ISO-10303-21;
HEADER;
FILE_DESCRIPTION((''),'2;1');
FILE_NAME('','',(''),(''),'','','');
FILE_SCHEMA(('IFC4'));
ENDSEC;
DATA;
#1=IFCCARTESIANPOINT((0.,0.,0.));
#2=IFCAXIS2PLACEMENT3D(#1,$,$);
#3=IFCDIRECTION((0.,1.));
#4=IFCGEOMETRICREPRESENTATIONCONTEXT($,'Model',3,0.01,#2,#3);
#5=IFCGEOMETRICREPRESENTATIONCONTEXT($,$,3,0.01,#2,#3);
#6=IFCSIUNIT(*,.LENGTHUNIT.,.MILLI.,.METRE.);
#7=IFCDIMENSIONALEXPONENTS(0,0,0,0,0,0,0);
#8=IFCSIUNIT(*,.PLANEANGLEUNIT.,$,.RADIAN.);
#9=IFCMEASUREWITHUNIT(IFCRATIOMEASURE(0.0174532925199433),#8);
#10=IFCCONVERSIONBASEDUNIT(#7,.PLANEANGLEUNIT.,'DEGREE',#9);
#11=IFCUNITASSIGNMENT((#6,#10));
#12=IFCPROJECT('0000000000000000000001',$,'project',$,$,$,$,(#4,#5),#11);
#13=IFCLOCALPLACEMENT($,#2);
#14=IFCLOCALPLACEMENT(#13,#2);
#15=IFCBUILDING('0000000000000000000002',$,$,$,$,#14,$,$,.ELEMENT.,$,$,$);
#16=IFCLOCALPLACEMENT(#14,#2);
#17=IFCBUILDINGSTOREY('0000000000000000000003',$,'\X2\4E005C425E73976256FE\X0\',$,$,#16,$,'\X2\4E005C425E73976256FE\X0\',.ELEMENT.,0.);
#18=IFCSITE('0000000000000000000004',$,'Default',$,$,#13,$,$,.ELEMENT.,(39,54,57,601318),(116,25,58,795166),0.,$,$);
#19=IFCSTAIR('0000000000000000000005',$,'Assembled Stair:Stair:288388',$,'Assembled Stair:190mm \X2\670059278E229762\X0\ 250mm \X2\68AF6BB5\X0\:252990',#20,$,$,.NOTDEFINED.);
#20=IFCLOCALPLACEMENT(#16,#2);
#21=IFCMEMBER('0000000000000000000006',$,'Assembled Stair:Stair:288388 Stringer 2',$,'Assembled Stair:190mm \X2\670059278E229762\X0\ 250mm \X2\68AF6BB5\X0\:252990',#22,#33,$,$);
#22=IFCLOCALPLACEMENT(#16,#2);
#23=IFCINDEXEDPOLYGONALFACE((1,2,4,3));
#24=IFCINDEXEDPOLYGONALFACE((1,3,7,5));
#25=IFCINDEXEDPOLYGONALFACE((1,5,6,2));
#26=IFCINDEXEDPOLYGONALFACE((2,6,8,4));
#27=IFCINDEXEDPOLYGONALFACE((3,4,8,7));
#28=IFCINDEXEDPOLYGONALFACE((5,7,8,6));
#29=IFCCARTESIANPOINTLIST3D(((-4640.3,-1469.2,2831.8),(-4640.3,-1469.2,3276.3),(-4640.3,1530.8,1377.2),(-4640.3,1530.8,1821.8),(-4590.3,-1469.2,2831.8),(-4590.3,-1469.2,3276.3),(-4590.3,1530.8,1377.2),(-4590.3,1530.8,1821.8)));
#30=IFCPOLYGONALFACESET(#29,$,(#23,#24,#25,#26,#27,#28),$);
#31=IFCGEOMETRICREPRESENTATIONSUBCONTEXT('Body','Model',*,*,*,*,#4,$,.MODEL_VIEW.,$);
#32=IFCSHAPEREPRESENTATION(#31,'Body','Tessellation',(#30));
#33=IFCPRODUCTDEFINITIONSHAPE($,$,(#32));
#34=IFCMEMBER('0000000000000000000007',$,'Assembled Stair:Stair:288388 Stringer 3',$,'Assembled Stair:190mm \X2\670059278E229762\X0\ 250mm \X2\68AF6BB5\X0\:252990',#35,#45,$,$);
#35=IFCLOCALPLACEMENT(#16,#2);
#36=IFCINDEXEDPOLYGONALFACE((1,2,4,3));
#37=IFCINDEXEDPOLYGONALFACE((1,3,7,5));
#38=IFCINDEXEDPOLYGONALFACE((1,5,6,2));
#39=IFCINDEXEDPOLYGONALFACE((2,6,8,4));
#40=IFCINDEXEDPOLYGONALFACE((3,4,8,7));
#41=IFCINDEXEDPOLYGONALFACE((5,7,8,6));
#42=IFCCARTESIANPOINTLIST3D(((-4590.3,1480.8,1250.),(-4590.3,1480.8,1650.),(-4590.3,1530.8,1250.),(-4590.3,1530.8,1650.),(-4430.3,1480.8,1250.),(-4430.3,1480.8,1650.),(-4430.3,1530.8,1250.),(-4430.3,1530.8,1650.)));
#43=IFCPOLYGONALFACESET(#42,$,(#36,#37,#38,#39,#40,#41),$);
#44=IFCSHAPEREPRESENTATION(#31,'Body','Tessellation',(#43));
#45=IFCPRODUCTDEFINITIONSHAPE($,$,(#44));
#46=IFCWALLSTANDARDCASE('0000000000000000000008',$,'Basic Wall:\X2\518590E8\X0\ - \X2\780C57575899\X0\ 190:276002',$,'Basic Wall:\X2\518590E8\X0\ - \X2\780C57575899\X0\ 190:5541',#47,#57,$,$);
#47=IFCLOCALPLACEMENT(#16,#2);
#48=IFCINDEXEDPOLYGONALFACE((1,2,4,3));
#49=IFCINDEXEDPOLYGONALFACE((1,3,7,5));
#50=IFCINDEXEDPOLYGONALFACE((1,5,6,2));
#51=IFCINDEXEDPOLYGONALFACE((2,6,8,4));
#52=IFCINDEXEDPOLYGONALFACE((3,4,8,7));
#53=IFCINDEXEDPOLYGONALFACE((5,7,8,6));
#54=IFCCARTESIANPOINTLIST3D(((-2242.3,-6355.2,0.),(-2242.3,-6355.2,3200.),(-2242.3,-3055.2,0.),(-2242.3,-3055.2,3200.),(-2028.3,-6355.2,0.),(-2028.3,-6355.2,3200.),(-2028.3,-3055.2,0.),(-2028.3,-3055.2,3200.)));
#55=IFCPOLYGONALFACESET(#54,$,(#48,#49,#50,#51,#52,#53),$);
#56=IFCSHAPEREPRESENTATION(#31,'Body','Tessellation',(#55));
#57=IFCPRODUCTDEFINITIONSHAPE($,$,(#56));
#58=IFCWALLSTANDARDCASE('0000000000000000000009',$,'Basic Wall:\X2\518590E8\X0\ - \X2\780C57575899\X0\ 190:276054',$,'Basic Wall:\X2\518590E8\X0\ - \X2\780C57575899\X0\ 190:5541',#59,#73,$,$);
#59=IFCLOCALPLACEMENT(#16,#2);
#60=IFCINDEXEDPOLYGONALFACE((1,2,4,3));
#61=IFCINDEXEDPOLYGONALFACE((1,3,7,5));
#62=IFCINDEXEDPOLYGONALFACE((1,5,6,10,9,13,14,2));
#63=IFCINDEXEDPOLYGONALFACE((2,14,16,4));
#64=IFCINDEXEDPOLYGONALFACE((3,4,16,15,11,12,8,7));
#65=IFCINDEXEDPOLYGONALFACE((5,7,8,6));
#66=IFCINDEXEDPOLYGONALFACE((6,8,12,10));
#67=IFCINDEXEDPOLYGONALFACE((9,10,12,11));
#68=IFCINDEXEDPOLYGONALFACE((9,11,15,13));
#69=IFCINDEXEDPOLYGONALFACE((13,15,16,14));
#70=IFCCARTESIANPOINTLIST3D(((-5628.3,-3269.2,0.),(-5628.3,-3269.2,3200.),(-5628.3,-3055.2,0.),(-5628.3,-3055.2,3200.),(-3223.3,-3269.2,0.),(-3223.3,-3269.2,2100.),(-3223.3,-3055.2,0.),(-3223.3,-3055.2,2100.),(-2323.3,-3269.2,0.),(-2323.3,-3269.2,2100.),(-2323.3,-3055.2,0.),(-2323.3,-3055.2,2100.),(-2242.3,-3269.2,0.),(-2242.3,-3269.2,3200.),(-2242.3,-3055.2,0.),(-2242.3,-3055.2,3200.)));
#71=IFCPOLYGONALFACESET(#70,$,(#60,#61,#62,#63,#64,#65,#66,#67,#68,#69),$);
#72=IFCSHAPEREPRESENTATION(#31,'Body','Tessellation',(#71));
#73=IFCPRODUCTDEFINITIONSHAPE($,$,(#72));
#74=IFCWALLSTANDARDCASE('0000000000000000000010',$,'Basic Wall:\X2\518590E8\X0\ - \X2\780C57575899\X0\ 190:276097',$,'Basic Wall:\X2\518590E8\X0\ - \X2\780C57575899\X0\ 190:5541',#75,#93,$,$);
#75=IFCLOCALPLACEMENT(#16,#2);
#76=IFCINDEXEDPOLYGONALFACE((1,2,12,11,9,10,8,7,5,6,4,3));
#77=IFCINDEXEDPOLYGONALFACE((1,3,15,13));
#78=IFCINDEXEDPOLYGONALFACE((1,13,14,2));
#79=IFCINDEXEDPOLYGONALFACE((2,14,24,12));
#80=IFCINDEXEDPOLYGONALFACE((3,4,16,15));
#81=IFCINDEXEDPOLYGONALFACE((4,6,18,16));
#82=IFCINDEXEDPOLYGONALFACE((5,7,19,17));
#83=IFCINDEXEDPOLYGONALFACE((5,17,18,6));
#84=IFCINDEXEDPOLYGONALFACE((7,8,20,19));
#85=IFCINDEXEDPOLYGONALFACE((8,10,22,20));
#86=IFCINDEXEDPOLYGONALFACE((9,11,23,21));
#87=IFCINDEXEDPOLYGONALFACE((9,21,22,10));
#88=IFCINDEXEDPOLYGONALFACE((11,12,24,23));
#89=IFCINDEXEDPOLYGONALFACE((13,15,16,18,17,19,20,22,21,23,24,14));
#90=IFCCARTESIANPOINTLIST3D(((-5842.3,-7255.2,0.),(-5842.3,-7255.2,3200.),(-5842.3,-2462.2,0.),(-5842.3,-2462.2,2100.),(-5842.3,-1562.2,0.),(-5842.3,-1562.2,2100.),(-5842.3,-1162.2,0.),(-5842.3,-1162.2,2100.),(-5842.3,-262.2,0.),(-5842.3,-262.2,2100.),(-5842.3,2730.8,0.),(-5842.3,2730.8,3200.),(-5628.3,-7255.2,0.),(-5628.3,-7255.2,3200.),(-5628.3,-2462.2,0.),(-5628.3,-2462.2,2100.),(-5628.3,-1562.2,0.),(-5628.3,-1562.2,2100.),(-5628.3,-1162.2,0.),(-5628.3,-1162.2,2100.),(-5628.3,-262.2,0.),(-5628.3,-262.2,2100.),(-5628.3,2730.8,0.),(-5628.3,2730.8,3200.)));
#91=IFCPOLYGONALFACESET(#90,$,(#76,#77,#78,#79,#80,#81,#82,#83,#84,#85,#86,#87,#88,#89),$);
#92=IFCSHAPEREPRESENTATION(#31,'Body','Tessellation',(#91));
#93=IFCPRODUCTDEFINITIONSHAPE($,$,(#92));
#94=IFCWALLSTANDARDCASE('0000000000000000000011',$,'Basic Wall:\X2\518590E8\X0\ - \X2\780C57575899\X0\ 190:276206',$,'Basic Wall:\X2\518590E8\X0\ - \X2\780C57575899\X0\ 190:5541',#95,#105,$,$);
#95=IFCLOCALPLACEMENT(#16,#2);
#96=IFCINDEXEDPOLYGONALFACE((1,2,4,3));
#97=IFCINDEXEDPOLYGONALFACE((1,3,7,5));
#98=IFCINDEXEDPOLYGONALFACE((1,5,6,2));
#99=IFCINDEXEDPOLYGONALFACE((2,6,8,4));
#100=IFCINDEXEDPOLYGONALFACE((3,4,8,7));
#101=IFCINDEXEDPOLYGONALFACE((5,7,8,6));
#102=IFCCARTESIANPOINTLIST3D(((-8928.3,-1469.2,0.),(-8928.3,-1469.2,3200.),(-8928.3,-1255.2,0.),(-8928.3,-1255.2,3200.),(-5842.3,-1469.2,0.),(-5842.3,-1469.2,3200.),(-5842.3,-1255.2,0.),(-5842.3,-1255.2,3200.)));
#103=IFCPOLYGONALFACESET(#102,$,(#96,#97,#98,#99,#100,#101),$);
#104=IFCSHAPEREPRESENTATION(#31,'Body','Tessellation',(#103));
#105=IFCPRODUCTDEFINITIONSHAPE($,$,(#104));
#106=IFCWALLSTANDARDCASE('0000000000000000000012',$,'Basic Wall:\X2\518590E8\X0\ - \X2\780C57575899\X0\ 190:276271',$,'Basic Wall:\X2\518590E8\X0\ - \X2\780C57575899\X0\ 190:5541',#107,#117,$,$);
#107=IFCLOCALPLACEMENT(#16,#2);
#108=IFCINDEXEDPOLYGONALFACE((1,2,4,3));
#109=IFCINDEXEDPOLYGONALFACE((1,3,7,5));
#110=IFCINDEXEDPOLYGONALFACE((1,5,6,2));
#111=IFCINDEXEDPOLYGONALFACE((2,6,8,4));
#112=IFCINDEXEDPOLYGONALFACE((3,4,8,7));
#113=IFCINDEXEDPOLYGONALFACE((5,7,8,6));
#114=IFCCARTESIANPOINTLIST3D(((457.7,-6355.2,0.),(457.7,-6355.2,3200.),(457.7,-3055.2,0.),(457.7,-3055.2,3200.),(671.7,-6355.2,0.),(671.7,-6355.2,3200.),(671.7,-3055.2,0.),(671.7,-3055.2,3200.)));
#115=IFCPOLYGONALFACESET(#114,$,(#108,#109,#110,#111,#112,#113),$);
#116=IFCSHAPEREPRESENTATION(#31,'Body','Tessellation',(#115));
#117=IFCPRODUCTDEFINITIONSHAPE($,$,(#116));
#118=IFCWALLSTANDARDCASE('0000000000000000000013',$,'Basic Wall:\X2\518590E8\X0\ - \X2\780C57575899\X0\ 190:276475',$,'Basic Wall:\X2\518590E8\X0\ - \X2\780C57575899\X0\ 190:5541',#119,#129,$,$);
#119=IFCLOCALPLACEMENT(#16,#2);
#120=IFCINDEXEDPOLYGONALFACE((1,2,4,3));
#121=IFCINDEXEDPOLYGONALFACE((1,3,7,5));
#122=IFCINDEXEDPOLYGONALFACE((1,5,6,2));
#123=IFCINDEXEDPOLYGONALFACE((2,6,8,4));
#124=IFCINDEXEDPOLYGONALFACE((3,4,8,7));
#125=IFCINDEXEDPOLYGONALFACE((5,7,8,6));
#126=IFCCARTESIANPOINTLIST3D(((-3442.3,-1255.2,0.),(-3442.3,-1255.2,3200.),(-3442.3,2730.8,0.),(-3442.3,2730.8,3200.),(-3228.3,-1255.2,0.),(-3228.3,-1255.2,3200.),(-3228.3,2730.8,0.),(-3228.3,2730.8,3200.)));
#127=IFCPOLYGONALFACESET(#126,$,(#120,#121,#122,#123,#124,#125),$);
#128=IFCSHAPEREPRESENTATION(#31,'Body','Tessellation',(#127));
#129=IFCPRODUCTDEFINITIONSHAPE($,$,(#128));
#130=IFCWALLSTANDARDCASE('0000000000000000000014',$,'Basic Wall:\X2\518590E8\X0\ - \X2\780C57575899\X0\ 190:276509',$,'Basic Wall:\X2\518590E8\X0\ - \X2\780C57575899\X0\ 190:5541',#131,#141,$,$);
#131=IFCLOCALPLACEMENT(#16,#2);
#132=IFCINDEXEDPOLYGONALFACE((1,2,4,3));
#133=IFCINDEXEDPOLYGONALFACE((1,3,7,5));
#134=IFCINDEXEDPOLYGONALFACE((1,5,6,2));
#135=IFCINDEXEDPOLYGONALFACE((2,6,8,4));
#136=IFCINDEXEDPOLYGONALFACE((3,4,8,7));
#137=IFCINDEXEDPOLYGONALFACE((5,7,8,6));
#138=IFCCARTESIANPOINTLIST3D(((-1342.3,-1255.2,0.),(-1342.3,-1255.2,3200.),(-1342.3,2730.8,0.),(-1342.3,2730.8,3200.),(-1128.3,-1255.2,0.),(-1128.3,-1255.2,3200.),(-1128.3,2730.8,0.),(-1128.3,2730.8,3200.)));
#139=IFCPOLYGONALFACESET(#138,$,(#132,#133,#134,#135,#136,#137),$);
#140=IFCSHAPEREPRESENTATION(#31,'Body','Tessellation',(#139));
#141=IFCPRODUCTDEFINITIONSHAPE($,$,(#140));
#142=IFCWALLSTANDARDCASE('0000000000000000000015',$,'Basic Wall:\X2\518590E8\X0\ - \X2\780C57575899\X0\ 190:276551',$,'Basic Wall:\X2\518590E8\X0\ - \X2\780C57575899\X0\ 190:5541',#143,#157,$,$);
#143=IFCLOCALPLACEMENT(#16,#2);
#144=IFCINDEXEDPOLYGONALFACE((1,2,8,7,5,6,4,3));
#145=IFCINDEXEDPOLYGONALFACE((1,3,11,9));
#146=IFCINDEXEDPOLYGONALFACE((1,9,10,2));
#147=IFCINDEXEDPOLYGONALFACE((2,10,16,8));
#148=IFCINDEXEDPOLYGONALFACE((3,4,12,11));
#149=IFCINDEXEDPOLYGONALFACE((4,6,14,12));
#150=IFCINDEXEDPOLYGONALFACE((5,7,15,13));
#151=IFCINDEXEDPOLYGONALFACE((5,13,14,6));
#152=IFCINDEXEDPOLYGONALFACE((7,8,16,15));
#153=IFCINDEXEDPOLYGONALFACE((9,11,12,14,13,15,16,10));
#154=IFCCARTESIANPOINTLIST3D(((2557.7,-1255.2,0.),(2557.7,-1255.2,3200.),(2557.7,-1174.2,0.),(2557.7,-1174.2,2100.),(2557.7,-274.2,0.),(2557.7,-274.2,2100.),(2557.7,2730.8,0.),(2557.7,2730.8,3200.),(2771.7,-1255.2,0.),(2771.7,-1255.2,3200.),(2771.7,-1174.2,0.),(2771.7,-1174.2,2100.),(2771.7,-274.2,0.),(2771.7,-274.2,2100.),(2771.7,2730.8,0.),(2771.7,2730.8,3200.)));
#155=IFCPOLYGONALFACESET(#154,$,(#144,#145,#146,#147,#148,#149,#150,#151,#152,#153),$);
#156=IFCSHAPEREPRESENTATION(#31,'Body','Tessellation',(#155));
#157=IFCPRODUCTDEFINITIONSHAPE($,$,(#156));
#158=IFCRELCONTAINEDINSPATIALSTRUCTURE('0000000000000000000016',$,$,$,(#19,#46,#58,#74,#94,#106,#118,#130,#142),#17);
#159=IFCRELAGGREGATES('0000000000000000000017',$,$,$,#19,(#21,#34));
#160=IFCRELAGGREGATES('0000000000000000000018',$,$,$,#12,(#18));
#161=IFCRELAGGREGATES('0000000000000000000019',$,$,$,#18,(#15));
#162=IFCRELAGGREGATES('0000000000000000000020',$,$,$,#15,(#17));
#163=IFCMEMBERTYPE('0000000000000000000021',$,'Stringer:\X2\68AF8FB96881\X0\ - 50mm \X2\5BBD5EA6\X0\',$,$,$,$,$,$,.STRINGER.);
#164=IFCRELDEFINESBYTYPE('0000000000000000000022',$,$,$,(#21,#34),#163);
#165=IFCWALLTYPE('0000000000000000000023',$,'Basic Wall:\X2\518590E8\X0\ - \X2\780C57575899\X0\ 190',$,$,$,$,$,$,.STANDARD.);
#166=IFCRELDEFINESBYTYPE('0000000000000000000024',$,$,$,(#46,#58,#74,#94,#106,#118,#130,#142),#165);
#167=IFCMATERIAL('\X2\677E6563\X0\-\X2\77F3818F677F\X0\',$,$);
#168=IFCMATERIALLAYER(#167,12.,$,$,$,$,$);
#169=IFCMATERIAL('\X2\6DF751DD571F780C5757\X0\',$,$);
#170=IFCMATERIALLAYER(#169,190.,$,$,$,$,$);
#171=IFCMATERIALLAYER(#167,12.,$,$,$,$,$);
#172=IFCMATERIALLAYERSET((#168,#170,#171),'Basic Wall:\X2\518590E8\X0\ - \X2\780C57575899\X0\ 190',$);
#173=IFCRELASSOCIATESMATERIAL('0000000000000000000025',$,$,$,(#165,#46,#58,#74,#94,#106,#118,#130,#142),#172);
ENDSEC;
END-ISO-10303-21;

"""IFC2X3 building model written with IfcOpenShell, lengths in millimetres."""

from ifc_helpers import new_model, entity, si_unit, converted_unit, direction, frame, frame_2d, origin, place, context, subcontext, project, spatial, polyline, rectangle, outline, extrude, material, layer, layer_set, layer_usage, type_object, element, aggregate, save


model = new_model("IFC2X3")

# Units and contexts
model_context = context("Model", 3, precision=0.01, world=origin(), true_north=direction((0.0, 1.0)))
context_of_model = context(None, 3, precision=0.01, world=origin(), true_north=direction((0.0, 1.0)))
body_context = subcontext(model_context, "Body", "Model", "MODEL_VIEW")
ifc_project = project(units=[si_unit("LENGTHUNIT", "METRE", prefix="MILLI"), converted_unit("PLANEANGLEUNIT", "DEGREE", entity("IfcRatioMeasure", 0.0174532925199433), si_unit("PLANEANGLEUNIT", "RADIAN"), dimensions=[0, 0, 0, 0, 0, 0, 0])], contexts=[model_context, context_of_model])

# Site, building, storey
site_placement = place(None, origin())
site = spatial("IfcSite", under=ifc_project, at=site_placement, Name="Default", CompositionType="ELEMENT", RefLatitude=(39, 54, 57, 601318), RefLongitude=(116, 25, 58, 795166), RefElevation=0.0)
building_placement = place(site_placement, origin())
building = spatial("IfcBuilding", under=site, at=building_placement, CompositionType="ELEMENT")
storey_placement = place(building_placement, origin())
storey = spatial("IfcBuildingStorey", under=building, at=storey_placement, Name="一层平面图", LongName="一层平面图", CompositionType="ELEMENT", Elevation=0.0)

# Stair, members
stair_placement = place(storey_placement, origin())
stair = element("IfcStair", 1, at=stair_placement, inside=storey, Name="Assembled Stair:Stair:288388", ObjectType="Assembled Stair:190mm 最大踢面 250mm 梯段:252990", ShapeType="NOTDEFINED")
member_type = type_object("IfcMemberType", Name="Stringer:梯边梁 - 50mm 宽度", PredefinedType="STRINGER")
member_1_placement = place(stair_placement, origin())
member_1 = element("IfcMember", 2, at=member_1_placement, type_object=member_type, Name="Assembled Stair:Stair:288388 Stringer 2", ObjectType="Assembled Stair:190mm 最大踢面 250mm 梯段:252990", context=body_context, shape_type="SweptSolid", body=[
    extrude(outline(polyline([(-1570.0, -200.0), (1764.0, -200.0), (1570.0, 200.0), (-1764.0, 200.0), (-1570.0, -200.0)])), frame((-4640.3, 30.8, 2326.8), z_axis=(1.0, 0.0, 0.0), x_axis=(0.0, -0.899814, 0.436274)), (0.0, 0.0, 1.0), 50.0),
])
member_2_placement = place(stair_placement, origin())
member_2 = element("IfcMember", 3, at=member_2_placement, type_object=member_type, Name="Assembled Stair:Stair:288388 Stringer 3", ObjectType="Assembled Stair:190mm 最大踢面 250mm 梯段:252990", context=body_context, shape_type="SweptSolid", body=[
    extrude(rectangle(XDim=160.0, YDim=50.0, at=frame_2d((0.0, 0.0), x_axis=(1.0, 0.0))), frame((-4510.3, 1505.8, 1250.0)), (0.0, 0.0, 1.0), 400.0),
])

# Wall
ifc_material_1 = material(Name="松散-石膏板")
ifc_layer_1 = layer(ifc_material_1, 12.0)
ifc_material_2 = material(Name="混凝土砌块")
ifc_layer_2 = layer(ifc_material_2, 190.0)
ifc_layer_3 = layer(ifc_material_1, 12.0)
ifc_layer_set_1 = layer_set([ifc_layer_1, ifc_layer_2, ifc_layer_3], Name="Basic Wall:内部 - 砌块墙 190")
ifc_layer_usage_1 = layer_usage(ifc_layer_set_1, "AXIS2", "NEGATIVE", 107.0)
wall_type_1 = type_object("IfcWallType", Name="Basic Wall:内部 - 砌块墙 190", PredefinedType="STANDARD", material=ifc_layer_set_1)
wall_1_placement = place(storey_placement, frame((-2135.3, -6355.2, 0.0), z_axis=(0.0, 0.0, 1.0), x_axis=(0.0, 1.0, 0.0)))
element("IfcWallStandardCase", 4, at=wall_1_placement, inside=storey, type_object=wall_type_1, material=ifc_layer_usage_1, Name="Basic Wall:内部 - 砌块墙 190:276002", ObjectType="Basic Wall:内部 - 砌块墙 190:5541", context=body_context, shape_type="SweptSolid", body=[
    extrude(rectangle(XDim=3300.0, YDim=214.0, at=frame_2d((1650.0, 0.0), x_axis=(-1.0, 0.0))), origin(), (0.0, 0.0, 1.0), 3200.0),
])

# Wall, opening
ifc_layer_usage_2 = layer_usage(ifc_layer_set_1, "AXIS2", "NEGATIVE", 107.0)
wall_2_placement = place(storey_placement, frame((-2242.3, -3162.2, 0.0), z_axis=(0.0, 0.0, 1.0), x_axis=(-1.0, 0.0, 0.0)))
wall_2 = element("IfcWallStandardCase", 5, at=wall_2_placement, inside=storey, type_object=wall_type_1, material=ifc_layer_usage_2, Name="Basic Wall:内部 - 砌块墙 190:276054", ObjectType="Basic Wall:内部 - 砌块墙 190:5541", context=body_context, shape_type="SweptSolid", body=[
    extrude(rectangle(XDim=3386.0, YDim=214.0, at=frame_2d((1693.0, 0.0), x_axis=(-1.0, 0.0))), origin(), (0.0, 0.0, 1.0), 3200.0),
])
opening_1_placement = place(wall_2_placement, frame((81.0, -107.0, 0.0)))
element("IfcOpeningElement", 6, at=opening_1_placement, cuts=wall_2, ObjectType="Opening", context=body_context, shape_type="SweptSolid", body=[
    extrude(rectangle(XDim=900.0, YDim=2100.0, at=frame_2d((1050.0, 450.0), x_axis=(0.0, 1.0))), frame((0.0, 0.0, 0.0), z_axis=(0.0, 1.0, 0.0), x_axis=(0.0, 0.0, 1.0)), (0.0, 0.0, 1.0), 214.0),
])

# Wall, openings
ifc_layer_usage_3 = layer_usage(ifc_layer_set_1, "AXIS2", "NEGATIVE", 107.0)
wall_3_placement = place(storey_placement, frame((-5735.3, 2730.8, 0.0), z_axis=(0.0, 0.0, 1.0), x_axis=(0.0, -1.0, 0.0)))
wall_3 = element("IfcWallStandardCase", 7, at=wall_3_placement, inside=storey, type_object=wall_type_1, material=ifc_layer_usage_3, Name="Basic Wall:内部 - 砌块墙 190:276097", ObjectType="Basic Wall:内部 - 砌块墙 190:5541", context=body_context, shape_type="SweptSolid", body=[
    extrude(rectangle(XDim=9986.0, YDim=214.0, at=frame_2d((4993.0, 0.0), x_axis=(-1.0, 0.0))), origin(), (0.0, 0.0, 1.0), 3200.0),
])
opening_2_placement = place(wall_3_placement, frame((5193.0, 107.0, 0.0)))
element("IfcOpeningElement", 8, at=opening_2_placement, cuts=wall_3, ObjectType="Opening", context=body_context, shape_type="SweptSolid", body=[
    extrude(rectangle(XDim=900.0, YDim=2100.0, at=frame_2d((1050.0, 450.0), x_axis=(0.0, -1.0))), frame((0.0, 0.0, 0.0), z_axis=(0.0, -1.0, 0.0), x_axis=(0.0, 0.0, 1.0)), (0.0, 0.0, 1.0), 214.0),
])
opening_3_placement = place(wall_3_placement, frame((3893.0, 107.0, 0.0)))
element("IfcOpeningElement", 9, at=opening_3_placement, cuts=wall_3, ObjectType="Opening", context=body_context, shape_type="SweptSolid", body=[
    extrude(rectangle(XDim=900.0, YDim=2100.0, at=frame_2d((1050.0, 450.0), x_axis=(0.0, 1.0))), frame((0.0, 0.0, 0.0), z_axis=(0.0, -1.0, 0.0), x_axis=(0.0, 0.0, 1.0)), (0.0, 0.0, 1.0), 214.0),
])

# Walls
ifc_layer_usage_4 = layer_usage(ifc_layer_set_1, "AXIS2", "NEGATIVE", 107.0)
wall_4_placement = place(storey_placement, frame((-8928.3, -1362.2, 0.0)))
element("IfcWallStandardCase", 10, at=wall_4_placement, inside=storey, type_object=wall_type_1, material=ifc_layer_usage_4, Name="Basic Wall:内部 - 砌块墙 190:276206", ObjectType="Basic Wall:内部 - 砌块墙 190:5541", context=body_context, shape_type="SweptSolid", body=[
    extrude(rectangle(XDim=3086.0, YDim=214.0, at=frame_2d((1543.0, 0.0), x_axis=(-1.0, 0.0))), origin(), (0.0, 0.0, 1.0), 3200.0),
])
ifc_layer_usage_5 = layer_usage(ifc_layer_set_1, "AXIS2", "NEGATIVE", 107.0)
wall_5_placement = place(storey_placement, frame((564.7, -6355.2, 0.0), z_axis=(0.0, 0.0, 1.0), x_axis=(0.0, 1.0, 0.0)))
element("IfcWallStandardCase", 11, at=wall_5_placement, inside=storey, type_object=wall_type_1, material=ifc_layer_usage_5, Name="Basic Wall:内部 - 砌块墙 190:276271", ObjectType="Basic Wall:内部 - 砌块墙 190:5541", context=body_context, shape_type="SweptSolid", body=[
    extrude(rectangle(XDim=3300.0, YDim=214.0, at=frame_2d((1650.0, 0.0), x_axis=(-1.0, 0.0))), origin(), (0.0, 0.0, 1.0), 3200.0),
])
ifc_layer_usage_6 = layer_usage(ifc_layer_set_1, "AXIS2", "NEGATIVE", 107.0)
wall_6_placement = place(storey_placement, frame((-3335.3, 2730.8, 0.0), z_axis=(0.0, 0.0, 1.0), x_axis=(0.0, -1.0, 0.0)))
element("IfcWallStandardCase", 12, at=wall_6_placement, inside=storey, type_object=wall_type_1, material=ifc_layer_usage_6, Name="Basic Wall:内部 - 砌块墙 190:276475", ObjectType="Basic Wall:内部 - 砌块墙 190:5541", context=body_context, shape_type="SweptSolid", body=[
    extrude(rectangle(XDim=3986.0, YDim=214.0, at=frame_2d((1993.0, 0.0), x_axis=(-1.0, 0.0))), origin(), (0.0, 0.0, 1.0), 3200.0),
])
ifc_layer_usage_7 = layer_usage(ifc_layer_set_1, "AXIS2", "NEGATIVE", 107.0)
wall_7_placement = place(storey_placement, frame((-1235.3, 2730.8, 0.0), z_axis=(0.0, 0.0, 1.0), x_axis=(0.0, -1.0, 0.0)))
element("IfcWallStandardCase", 13, at=wall_7_placement, inside=storey, type_object=wall_type_1, material=ifc_layer_usage_7, Name="Basic Wall:内部 - 砌块墙 190:276509", ObjectType="Basic Wall:内部 - 砌块墙 190:5541", context=body_context, shape_type="SweptSolid", body=[
    extrude(rectangle(XDim=3986.0, YDim=214.0, at=frame_2d((1993.0, 0.0), x_axis=(-1.0, 0.0))), origin(), (0.0, 0.0, 1.0), 3200.0),
])

# Wall, opening
ifc_layer_usage_8 = layer_usage(ifc_layer_set_1, "AXIS2", "NEGATIVE", 107.0)
wall_8_placement = place(storey_placement, frame((2664.7, 2730.8, 0.0), z_axis=(0.0, 0.0, 1.0), x_axis=(0.0, -1.0, 0.0)))
wall_8 = element("IfcWallStandardCase", 14, at=wall_8_placement, inside=storey, type_object=wall_type_1, material=ifc_layer_usage_8, Name="Basic Wall:内部 - 砌块墙 190:276551", ObjectType="Basic Wall:内部 - 砌块墙 190:5541", context=body_context, shape_type="SweptSolid", body=[
    extrude(rectangle(XDim=3986.0, YDim=214.0, at=frame_2d((1993.0, 0.0), x_axis=(-1.0, 0.0))), origin(), (0.0, 0.0, 1.0), 3200.0),
])
opening_4_placement = place(wall_8_placement, frame((3005.0, -107.0, 0.0)))
element("IfcOpeningElement", 15, at=opening_4_placement, cuts=wall_8, ObjectType="Opening", context=body_context, shape_type="SweptSolid", body=[
    extrude(rectangle(XDim=900.0, YDim=2100.0, at=frame_2d((1050.0, 450.0), x_axis=(0.0, -1.0))), frame((0.0, 0.0, 0.0), z_axis=(0.0, 1.0, 0.0), x_axis=(0.0, 0.0, 1.0)), (0.0, 0.0, 1.0), 214.0),
])

aggregate(stair, [member_1, member_2])

save(model, "model.ifc")
